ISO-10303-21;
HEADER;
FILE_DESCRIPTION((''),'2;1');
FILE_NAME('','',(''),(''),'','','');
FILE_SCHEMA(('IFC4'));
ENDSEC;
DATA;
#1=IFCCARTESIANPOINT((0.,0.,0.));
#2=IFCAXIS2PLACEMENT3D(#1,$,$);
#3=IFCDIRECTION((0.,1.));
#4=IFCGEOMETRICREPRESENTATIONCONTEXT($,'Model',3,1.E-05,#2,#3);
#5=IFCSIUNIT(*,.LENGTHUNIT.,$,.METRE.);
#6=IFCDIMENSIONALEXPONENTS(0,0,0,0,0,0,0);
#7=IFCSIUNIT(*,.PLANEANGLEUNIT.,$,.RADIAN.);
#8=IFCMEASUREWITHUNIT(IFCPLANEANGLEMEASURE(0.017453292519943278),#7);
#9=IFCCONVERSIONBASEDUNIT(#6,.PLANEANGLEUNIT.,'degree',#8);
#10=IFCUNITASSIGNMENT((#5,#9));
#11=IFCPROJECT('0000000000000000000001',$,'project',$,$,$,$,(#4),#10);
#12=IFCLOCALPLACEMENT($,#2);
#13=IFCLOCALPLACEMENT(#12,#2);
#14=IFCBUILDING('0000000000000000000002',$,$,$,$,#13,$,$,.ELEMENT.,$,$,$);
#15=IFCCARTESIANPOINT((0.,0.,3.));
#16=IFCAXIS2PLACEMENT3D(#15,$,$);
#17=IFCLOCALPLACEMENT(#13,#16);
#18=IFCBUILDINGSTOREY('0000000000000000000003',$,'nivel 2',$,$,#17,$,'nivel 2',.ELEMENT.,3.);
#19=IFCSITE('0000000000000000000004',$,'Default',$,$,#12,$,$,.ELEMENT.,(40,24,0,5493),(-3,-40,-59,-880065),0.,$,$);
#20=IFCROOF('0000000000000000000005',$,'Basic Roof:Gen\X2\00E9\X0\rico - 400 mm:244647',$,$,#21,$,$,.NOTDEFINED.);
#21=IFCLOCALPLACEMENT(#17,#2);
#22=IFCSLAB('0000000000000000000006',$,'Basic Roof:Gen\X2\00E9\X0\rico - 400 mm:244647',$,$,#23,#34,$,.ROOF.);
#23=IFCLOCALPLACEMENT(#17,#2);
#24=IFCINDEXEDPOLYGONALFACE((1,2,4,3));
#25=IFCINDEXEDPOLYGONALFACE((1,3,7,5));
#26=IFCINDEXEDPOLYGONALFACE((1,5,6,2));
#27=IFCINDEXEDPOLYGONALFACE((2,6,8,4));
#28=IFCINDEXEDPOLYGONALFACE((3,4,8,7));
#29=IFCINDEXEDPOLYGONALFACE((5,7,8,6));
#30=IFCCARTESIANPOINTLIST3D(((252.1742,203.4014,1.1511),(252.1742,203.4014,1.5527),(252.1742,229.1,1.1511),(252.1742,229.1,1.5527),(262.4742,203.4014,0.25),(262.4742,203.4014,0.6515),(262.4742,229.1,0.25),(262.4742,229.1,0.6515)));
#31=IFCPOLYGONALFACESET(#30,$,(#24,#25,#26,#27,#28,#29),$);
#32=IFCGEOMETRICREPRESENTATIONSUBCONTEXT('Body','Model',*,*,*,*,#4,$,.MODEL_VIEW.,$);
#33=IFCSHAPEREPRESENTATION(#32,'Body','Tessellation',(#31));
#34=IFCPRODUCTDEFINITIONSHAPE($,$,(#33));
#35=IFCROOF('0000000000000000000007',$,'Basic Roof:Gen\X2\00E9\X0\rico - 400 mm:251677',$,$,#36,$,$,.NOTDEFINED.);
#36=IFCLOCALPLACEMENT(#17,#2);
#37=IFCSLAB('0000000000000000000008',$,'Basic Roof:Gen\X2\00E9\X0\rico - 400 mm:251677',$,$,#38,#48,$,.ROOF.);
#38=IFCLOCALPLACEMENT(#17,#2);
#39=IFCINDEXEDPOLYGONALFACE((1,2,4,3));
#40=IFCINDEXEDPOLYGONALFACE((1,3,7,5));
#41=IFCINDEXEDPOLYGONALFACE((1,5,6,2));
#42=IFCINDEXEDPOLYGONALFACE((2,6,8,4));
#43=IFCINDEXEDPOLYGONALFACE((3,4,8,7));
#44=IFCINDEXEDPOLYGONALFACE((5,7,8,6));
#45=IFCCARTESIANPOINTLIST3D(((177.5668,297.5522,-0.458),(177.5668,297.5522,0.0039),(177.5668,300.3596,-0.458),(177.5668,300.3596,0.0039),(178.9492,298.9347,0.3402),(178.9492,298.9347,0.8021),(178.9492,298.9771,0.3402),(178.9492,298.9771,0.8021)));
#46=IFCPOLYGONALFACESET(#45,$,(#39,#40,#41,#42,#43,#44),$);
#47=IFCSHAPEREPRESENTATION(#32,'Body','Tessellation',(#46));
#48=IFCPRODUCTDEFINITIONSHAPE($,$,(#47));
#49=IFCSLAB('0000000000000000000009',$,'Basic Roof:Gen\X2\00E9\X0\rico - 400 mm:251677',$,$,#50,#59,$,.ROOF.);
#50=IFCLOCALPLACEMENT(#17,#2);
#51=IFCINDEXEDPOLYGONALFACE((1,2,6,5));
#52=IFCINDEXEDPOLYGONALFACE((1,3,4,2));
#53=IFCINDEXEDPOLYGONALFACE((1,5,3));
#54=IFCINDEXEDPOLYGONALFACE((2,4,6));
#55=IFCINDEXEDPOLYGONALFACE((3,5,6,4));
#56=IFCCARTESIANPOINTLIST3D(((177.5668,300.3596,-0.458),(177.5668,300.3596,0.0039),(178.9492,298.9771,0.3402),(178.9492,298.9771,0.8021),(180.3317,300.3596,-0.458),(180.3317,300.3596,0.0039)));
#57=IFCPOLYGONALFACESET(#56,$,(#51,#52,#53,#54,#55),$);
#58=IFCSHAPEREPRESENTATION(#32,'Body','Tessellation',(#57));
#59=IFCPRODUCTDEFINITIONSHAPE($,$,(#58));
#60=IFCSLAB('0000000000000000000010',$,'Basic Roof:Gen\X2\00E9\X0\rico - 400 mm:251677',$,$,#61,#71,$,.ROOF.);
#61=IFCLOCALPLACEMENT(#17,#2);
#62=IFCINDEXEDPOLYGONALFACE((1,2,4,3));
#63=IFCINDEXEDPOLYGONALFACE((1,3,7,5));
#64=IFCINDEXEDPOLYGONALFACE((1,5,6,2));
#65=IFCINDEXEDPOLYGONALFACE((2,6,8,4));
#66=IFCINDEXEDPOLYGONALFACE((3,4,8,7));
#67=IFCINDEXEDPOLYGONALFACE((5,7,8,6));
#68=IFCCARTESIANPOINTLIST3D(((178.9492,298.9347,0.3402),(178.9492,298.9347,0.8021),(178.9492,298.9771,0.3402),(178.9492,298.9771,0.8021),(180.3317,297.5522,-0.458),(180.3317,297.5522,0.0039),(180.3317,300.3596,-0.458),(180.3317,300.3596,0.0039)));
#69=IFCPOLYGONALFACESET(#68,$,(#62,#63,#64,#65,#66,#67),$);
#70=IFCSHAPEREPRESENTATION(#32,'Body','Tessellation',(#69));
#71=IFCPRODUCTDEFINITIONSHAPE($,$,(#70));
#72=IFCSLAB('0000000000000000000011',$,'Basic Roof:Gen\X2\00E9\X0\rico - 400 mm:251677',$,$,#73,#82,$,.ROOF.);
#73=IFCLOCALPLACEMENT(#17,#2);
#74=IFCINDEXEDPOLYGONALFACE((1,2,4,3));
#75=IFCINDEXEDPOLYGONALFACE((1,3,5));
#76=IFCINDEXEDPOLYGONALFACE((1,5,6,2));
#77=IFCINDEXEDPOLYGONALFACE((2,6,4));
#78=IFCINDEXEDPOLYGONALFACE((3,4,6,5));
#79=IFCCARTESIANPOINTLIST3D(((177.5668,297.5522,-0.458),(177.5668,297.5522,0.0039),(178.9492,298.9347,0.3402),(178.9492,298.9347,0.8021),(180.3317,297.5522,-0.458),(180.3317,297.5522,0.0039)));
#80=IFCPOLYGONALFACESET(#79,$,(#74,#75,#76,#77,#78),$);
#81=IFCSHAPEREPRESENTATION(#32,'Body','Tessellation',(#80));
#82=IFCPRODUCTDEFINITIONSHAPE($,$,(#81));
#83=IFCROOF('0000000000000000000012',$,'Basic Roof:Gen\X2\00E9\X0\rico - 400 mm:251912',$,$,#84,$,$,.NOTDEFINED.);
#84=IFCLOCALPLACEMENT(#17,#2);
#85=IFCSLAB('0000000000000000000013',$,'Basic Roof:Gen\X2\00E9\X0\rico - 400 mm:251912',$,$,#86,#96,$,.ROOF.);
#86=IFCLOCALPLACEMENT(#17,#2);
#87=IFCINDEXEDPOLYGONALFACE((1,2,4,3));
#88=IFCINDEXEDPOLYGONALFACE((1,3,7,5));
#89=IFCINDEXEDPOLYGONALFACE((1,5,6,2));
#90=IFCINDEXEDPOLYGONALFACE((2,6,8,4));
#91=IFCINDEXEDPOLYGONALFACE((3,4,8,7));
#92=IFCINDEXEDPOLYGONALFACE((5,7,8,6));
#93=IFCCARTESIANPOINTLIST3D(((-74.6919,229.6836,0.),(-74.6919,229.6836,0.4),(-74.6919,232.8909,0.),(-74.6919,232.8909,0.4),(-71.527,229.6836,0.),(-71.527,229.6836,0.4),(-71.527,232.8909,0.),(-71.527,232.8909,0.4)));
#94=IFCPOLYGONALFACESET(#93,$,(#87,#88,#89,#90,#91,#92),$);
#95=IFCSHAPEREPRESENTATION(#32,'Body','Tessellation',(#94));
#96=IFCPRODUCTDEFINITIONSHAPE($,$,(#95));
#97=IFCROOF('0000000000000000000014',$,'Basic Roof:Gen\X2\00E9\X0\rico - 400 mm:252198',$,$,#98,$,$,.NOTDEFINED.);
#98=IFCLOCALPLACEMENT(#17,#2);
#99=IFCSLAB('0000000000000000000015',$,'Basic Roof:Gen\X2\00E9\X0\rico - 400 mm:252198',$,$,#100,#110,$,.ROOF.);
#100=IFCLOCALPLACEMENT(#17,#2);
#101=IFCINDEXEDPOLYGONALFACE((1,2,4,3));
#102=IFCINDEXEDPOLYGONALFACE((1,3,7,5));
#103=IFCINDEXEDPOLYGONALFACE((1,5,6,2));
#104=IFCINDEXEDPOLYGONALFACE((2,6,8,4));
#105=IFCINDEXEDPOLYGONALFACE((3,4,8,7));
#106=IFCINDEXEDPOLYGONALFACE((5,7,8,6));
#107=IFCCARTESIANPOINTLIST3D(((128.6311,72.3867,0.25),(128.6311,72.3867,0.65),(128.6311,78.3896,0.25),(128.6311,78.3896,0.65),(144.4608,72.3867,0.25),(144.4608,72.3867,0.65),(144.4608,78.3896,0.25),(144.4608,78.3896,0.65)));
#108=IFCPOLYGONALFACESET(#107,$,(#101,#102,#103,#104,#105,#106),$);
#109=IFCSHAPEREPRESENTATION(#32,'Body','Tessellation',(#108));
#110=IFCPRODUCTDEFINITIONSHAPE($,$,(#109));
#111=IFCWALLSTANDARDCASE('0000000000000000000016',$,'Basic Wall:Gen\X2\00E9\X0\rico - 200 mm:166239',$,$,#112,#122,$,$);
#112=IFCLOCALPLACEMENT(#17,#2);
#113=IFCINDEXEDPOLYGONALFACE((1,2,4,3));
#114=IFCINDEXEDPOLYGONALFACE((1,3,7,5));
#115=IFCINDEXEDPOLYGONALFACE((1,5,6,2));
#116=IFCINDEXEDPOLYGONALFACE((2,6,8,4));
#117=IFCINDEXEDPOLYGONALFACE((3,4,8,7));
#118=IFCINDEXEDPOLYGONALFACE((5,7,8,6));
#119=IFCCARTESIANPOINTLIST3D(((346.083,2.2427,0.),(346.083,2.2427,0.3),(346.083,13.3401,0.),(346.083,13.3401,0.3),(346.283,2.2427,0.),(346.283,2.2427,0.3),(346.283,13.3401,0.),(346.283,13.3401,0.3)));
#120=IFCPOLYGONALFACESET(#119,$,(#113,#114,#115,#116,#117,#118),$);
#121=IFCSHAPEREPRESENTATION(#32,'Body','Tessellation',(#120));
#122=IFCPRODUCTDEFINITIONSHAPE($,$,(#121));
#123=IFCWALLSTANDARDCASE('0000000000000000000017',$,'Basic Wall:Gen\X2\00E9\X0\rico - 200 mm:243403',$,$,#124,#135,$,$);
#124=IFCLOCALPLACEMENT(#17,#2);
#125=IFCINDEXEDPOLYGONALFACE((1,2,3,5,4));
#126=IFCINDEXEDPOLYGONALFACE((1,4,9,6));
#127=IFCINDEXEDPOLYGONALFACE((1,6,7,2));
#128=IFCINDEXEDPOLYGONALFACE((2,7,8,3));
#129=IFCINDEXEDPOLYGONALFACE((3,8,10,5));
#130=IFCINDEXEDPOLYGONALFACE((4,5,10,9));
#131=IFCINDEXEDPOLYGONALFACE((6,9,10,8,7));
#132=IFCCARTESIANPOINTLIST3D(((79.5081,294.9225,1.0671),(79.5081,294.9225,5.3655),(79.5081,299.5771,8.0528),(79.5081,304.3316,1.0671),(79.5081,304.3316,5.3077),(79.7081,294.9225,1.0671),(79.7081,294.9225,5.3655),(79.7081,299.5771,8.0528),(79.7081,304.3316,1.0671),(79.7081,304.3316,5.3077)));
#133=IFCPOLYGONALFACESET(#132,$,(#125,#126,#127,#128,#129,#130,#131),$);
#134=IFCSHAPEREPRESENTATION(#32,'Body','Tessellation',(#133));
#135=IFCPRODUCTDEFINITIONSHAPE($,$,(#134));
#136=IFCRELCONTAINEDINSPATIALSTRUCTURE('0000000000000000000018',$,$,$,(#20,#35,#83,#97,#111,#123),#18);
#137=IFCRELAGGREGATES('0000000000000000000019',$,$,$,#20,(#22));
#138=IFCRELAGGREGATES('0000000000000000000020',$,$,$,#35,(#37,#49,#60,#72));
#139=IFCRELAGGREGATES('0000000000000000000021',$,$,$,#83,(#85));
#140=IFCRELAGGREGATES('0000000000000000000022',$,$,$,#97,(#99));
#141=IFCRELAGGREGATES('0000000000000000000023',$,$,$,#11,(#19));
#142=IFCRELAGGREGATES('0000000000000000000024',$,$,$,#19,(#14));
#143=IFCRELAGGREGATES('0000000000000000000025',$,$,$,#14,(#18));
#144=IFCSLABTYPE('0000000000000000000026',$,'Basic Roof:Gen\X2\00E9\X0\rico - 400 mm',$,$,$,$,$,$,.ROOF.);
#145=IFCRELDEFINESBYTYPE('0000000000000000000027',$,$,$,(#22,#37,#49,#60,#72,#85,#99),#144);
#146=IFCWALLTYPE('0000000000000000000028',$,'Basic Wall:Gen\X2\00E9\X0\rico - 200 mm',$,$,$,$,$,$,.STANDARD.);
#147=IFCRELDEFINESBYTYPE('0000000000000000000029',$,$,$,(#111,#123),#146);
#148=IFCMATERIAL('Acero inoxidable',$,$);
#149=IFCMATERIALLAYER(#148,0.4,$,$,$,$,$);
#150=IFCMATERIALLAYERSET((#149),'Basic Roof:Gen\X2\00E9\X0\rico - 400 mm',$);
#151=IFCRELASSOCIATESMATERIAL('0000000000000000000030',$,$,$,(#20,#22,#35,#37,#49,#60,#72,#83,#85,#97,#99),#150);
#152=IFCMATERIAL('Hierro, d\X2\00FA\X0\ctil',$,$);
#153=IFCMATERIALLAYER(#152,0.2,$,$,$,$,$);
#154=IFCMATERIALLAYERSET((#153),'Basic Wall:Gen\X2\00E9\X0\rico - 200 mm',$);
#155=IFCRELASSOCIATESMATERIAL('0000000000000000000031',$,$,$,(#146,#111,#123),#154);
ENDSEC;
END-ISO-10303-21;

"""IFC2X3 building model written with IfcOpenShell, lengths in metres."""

from ifc_helpers import new_model, entity, si_unit, converted_unit, direction, frame, frame_2d, origin, place, context, subcontext, project, spatial, polyline, rectangle, outline, extrude, clip, bounded_halfspace, material, layer, layer_set, layer_usage, type_object, element, aggregate, save


model = new_model("IFC2X3")

# Units and contexts
model_context = context("Model", 3, precision=1e-05, world=origin(), true_north=direction((0.0, 1.0)))
body_context = subcontext(model_context, "Body", "Model", "MODEL_VIEW")
ifc_project = project(units=[si_unit("LENGTHUNIT", "METRE"), converted_unit("PLANEANGLEUNIT", "degree", entity("IfcPlaneAngleMeasure", 0.017453292519943278), si_unit("PLANEANGLEUNIT", "RADIAN"), dimensions=[0, 0, 0, 0, 0, 0, 0])], contexts=[model_context])

# Site, building, storey
site_placement = place(None, origin())
site = spatial("IfcSite", under=ifc_project, at=site_placement, Name="Default", CompositionType="ELEMENT", RefLatitude=(40, 24, 0, 5493), RefLongitude=(-3, -40, -59, -880065), RefElevation=0.0)
building_placement = place(site_placement, origin())
building = spatial("IfcBuilding", under=site, at=building_placement, CompositionType="ELEMENT")
storey_placement = place(building_placement, frame((0.0, 0.0, 3.0)))
storey = spatial("IfcBuildingStorey", under=building, at=storey_placement, Name="nivel 2", LongName="nivel 2", CompositionType="ELEMENT", Elevation=3.0)

# Shared definitions
ifc_material_1 = material(Name="Acero inoxidable")
ifc_layer_1 = layer(ifc_material_1, 0.4)
ifc_layer_set_1 = layer_set([ifc_layer_1], Name="Basic Roof:Genérico - 400 mm")
slab_type = type_object("IfcSlabType", Name="Basic Roof:Genérico - 400 mm", PredefinedType="ROOF")

# Roof, slab
roof_1_placement = place(storey_placement, frame((252.1742, 203.4014, 0.25)))
roof_1 = element("IfcRoof", 1, at=roof_1_placement, inside=storey, material=ifc_layer_set_1, Name="Basic Roof:Genérico - 400 mm:244647", ShapeType="NOTDEFINED")
slab_1_placement = place(roof_1_placement, origin())
slab_1 = element("IfcSlab", 2, at=slab_1_placement, type_object=slab_type, material=ifc_layer_set_1, Name="Basic Roof:Genérico - 400 mm:244647", PredefinedType="ROOF", context=body_context, shape_type="SweptSolid", body=[
    extrude(rectangle(XDim=25.6986, YDim=10.3393, at=frame_2d((0.0, 0.0), x_axis=(0.0, 1.0))), frame((5.15, 12.8493, 0.4506), z_axis=(0.087156, 0.0, 0.996195), x_axis=(0.996195, 0.0, -0.087156)), (-0.087156, 0.0, 0.996195), 0.4015),
])
aggregate(roof_1, [slab_1])

# Roof, slabs
roof_2_placement = place(storey_placement, frame((177.5668, 297.5522, -0.458)))
roof_2 = element("IfcRoof", 3, at=roof_2_placement, inside=storey, material=ifc_layer_set_1, Name="Basic Roof:Genérico - 400 mm:251677", ShapeType="NOTDEFINED")
slab_2_placement = place(roof_2_placement, origin())
slab_2 = element("IfcSlab", 4, at=slab_2_placement, type_object=slab_type, material=ifc_layer_set_1, Name="Basic Roof:Genérico - 400 mm:251677", PredefinedType="ROOF", context=body_context, shape_type="SweptSolid", body=[
    extrude(outline(polyline([(-0.7982, 1.4037), (-0.7982, -1.4037), (0.7982, -0.0212), (0.7982, 0.0212), (-0.7982, 1.4037)])), frame((0.6912, 1.4037, 0.3991), z_axis=(-0.5, 0.0, 0.866025), x_axis=(0.866025, 0.0, 0.5)), (0.5, 0.0, 0.866025), 0.4619),
])
slab_3_placement = place(roof_2_placement, origin())
slab_3 = element("IfcSlab", 5, at=slab_3_placement, type_object=slab_type, material=ifc_layer_set_1, Name="Basic Roof:Genérico - 400 mm:251677", PredefinedType="ROOF", context=body_context, shape_type="SweptSolid", body=[
    extrude(outline(polyline([(0.0, -0.7982), (1.3825, 0.7982), (-1.3825, 0.7982), (0.0, -0.7982)])), frame((1.3825, 2.1161, 0.3991), z_axis=(0.0, 0.5, 0.866025), x_axis=(1.0, 0.0, 0.0)), (0.0, -0.5, 0.866025), 0.4619),
])
slab_4_placement = place(roof_2_placement, origin())
slab_4 = element("IfcSlab", 6, at=slab_4_placement, type_object=slab_type, material=ifc_layer_set_1, Name="Basic Roof:Genérico - 400 mm:251677", PredefinedType="ROOF", context=body_context, shape_type="SweptSolid", body=[
    extrude(outline(polyline([(0.7982, -1.4037), (0.7982, 1.4037), (-0.7982, 0.0212), (-0.7982, -0.0212), (0.7982, -1.4037)])), frame((2.0737, 1.4037, 0.3991), z_axis=(0.5, 0.0, 0.866025), x_axis=(0.866025, 0.0, -0.5)), (-0.5, 0.0, 0.866025), 0.4619),
])
slab_5_placement = place(roof_2_placement, origin())
slab_5 = element("IfcSlab", 7, at=slab_5_placement, type_object=slab_type, material=ifc_layer_set_1, Name="Basic Roof:Genérico - 400 mm:251677", PredefinedType="ROOF", context=body_context, shape_type="SweptSolid", body=[
    extrude(outline(polyline([(-1.3825, -0.7982), (1.3825, -0.7982), (0.0, 0.7982), (-1.3825, -0.7982)])), frame((1.3825, 0.6912, 0.3991), z_axis=(0.0, -0.5, 0.866025), x_axis=(1.0, 0.0, 0.0)), (0.0, 0.5, 0.866025), 0.4619),
])
aggregate(roof_2, [slab_2, slab_3, slab_4, slab_5])

# Roofs, slabs
roof_3_placement = place(storey_placement, frame((-74.6919, 229.6836, 0.0)))
roof_3 = element("IfcRoof", 8, at=roof_3_placement, inside=storey, material=ifc_layer_set_1, Name="Basic Roof:Genérico - 400 mm:251912", ShapeType="NOTDEFINED")
slab_6_placement = place(roof_3_placement, origin())
slab_6 = element("IfcSlab", 9, at=slab_6_placement, type_object=slab_type, material=ifc_layer_set_1, Name="Basic Roof:Genérico - 400 mm:251912", PredefinedType="ROOF", context=body_context, shape_type="SweptSolid", body=[
    extrude(rectangle(XDim=3.165, YDim=3.2073, at=frame_2d((0.0, 0.0), x_axis=(1.0, 0.0))), frame((1.5825, 1.6037, 0.0)), (0.0, 0.0, 1.0), 0.4),
])
aggregate(roof_3, [slab_6])
roof_4_placement = place(storey_placement, frame((128.6311, 72.3867, 0.25)))
roof_4 = element("IfcRoof", 10, at=roof_4_placement, inside=storey, material=ifc_layer_set_1, Name="Basic Roof:Genérico - 400 mm:252198", ShapeType="NOTDEFINED")
slab_7_placement = place(roof_4_placement, origin())
slab_7 = element("IfcSlab", 11, at=slab_7_placement, type_object=slab_type, material=ifc_layer_set_1, Name="Basic Roof:Genérico - 400 mm:252198", PredefinedType="ROOF", context=body_context, shape_type="SweptSolid", body=[
    extrude(rectangle(XDim=6.0029, YDim=15.8297, at=frame_2d((0.0, 0.0), x_axis=(0.0, 1.0))), frame((7.9148, 3.0014, 0.0)), (0.0, 0.0, 1.0), 0.4),
])
aggregate(roof_4, [slab_7])

# Walls
ifc_material_2 = material(Name="Hierro, dúctil")
ifc_layer_2 = layer(ifc_material_2, 0.2)
ifc_layer_set_2 = layer_set([ifc_layer_2], Name="Basic Wall:Genérico - 200 mm")
ifc_layer_usage_1 = layer_usage(ifc_layer_set_2, "AXIS2", "NEGATIVE", 0.1)
wall_type = type_object("IfcWallType", Name="Basic Wall:Genérico - 200 mm", PredefinedType="STANDARD", material=ifc_layer_set_2)
wall_1_placement = place(storey_placement, frame((346.183, 2.2427, 0.0), z_axis=(0.0, 0.0, 1.0), x_axis=(0.0, 1.0, 0.0)))
element("IfcWallStandardCase", 12, at=wall_1_placement, inside=storey, type_object=wall_type, material=ifc_layer_usage_1, Name="Basic Wall:Genérico - 200 mm:166239", context=body_context, shape_type="SweptSolid", body=[
    extrude(rectangle(XDim=11.0975, YDim=0.2, at=frame_2d((5.5487, 0.0), x_axis=(-1.0, 0.0))), origin(), (0.0, 0.0, 1.0), 0.3),
])
ifc_layer_usage_2 = layer_usage(ifc_layer_set_2, "AXIS2", "NEGATIVE", 0.1)
wall_2_placement = place(storey_placement, frame((79.6081, 294.9225, 1.0671), z_axis=(0.0, 0.0, 1.0), x_axis=(0.0, 1.0, 0.0)))
element("IfcWallStandardCase", 13, at=wall_2_placement, inside=storey, type_object=wall_type, material=ifc_layer_usage_2, Name="Basic Wall:Genérico - 200 mm:243403", context=body_context, shape_type="Clipping", body=[
    clip(clip(extrude(rectangle(XDim=9.4091, YDim=0.2, at=frame_2d((4.7046, 0.0), x_axis=(-1.0, 0.0))), origin(), (0.0, 0.0, 1.0), 6.9857), bounded_halfspace(frame((4.6546, -0.1, 6.9857), z_axis=(0.5, 0.0, 0.866025), x_axis=(0.0, 1.0, 0.0)), False, frame((4.6546, -0.1, 6.9857)), polyline([(0.0, 0.0), (4.7546, 0.0), (4.7546, 0.2), (0.0, 0.2), (0.0, 0.0)]))), bounded_halfspace(frame((0.0, -0.1, 4.2984), z_axis=(-0.5, 0.0, 0.866025), x_axis=(0.0, -1.0, 0.0)), False, frame((0.0, -0.1, 4.2984)), polyline([(0.0, 0.0), (4.6546, 0.0), (4.6546, 0.2), (0.0, 0.2), (0.0, 0.0)]))),
])

save(model, "model.ifc")
